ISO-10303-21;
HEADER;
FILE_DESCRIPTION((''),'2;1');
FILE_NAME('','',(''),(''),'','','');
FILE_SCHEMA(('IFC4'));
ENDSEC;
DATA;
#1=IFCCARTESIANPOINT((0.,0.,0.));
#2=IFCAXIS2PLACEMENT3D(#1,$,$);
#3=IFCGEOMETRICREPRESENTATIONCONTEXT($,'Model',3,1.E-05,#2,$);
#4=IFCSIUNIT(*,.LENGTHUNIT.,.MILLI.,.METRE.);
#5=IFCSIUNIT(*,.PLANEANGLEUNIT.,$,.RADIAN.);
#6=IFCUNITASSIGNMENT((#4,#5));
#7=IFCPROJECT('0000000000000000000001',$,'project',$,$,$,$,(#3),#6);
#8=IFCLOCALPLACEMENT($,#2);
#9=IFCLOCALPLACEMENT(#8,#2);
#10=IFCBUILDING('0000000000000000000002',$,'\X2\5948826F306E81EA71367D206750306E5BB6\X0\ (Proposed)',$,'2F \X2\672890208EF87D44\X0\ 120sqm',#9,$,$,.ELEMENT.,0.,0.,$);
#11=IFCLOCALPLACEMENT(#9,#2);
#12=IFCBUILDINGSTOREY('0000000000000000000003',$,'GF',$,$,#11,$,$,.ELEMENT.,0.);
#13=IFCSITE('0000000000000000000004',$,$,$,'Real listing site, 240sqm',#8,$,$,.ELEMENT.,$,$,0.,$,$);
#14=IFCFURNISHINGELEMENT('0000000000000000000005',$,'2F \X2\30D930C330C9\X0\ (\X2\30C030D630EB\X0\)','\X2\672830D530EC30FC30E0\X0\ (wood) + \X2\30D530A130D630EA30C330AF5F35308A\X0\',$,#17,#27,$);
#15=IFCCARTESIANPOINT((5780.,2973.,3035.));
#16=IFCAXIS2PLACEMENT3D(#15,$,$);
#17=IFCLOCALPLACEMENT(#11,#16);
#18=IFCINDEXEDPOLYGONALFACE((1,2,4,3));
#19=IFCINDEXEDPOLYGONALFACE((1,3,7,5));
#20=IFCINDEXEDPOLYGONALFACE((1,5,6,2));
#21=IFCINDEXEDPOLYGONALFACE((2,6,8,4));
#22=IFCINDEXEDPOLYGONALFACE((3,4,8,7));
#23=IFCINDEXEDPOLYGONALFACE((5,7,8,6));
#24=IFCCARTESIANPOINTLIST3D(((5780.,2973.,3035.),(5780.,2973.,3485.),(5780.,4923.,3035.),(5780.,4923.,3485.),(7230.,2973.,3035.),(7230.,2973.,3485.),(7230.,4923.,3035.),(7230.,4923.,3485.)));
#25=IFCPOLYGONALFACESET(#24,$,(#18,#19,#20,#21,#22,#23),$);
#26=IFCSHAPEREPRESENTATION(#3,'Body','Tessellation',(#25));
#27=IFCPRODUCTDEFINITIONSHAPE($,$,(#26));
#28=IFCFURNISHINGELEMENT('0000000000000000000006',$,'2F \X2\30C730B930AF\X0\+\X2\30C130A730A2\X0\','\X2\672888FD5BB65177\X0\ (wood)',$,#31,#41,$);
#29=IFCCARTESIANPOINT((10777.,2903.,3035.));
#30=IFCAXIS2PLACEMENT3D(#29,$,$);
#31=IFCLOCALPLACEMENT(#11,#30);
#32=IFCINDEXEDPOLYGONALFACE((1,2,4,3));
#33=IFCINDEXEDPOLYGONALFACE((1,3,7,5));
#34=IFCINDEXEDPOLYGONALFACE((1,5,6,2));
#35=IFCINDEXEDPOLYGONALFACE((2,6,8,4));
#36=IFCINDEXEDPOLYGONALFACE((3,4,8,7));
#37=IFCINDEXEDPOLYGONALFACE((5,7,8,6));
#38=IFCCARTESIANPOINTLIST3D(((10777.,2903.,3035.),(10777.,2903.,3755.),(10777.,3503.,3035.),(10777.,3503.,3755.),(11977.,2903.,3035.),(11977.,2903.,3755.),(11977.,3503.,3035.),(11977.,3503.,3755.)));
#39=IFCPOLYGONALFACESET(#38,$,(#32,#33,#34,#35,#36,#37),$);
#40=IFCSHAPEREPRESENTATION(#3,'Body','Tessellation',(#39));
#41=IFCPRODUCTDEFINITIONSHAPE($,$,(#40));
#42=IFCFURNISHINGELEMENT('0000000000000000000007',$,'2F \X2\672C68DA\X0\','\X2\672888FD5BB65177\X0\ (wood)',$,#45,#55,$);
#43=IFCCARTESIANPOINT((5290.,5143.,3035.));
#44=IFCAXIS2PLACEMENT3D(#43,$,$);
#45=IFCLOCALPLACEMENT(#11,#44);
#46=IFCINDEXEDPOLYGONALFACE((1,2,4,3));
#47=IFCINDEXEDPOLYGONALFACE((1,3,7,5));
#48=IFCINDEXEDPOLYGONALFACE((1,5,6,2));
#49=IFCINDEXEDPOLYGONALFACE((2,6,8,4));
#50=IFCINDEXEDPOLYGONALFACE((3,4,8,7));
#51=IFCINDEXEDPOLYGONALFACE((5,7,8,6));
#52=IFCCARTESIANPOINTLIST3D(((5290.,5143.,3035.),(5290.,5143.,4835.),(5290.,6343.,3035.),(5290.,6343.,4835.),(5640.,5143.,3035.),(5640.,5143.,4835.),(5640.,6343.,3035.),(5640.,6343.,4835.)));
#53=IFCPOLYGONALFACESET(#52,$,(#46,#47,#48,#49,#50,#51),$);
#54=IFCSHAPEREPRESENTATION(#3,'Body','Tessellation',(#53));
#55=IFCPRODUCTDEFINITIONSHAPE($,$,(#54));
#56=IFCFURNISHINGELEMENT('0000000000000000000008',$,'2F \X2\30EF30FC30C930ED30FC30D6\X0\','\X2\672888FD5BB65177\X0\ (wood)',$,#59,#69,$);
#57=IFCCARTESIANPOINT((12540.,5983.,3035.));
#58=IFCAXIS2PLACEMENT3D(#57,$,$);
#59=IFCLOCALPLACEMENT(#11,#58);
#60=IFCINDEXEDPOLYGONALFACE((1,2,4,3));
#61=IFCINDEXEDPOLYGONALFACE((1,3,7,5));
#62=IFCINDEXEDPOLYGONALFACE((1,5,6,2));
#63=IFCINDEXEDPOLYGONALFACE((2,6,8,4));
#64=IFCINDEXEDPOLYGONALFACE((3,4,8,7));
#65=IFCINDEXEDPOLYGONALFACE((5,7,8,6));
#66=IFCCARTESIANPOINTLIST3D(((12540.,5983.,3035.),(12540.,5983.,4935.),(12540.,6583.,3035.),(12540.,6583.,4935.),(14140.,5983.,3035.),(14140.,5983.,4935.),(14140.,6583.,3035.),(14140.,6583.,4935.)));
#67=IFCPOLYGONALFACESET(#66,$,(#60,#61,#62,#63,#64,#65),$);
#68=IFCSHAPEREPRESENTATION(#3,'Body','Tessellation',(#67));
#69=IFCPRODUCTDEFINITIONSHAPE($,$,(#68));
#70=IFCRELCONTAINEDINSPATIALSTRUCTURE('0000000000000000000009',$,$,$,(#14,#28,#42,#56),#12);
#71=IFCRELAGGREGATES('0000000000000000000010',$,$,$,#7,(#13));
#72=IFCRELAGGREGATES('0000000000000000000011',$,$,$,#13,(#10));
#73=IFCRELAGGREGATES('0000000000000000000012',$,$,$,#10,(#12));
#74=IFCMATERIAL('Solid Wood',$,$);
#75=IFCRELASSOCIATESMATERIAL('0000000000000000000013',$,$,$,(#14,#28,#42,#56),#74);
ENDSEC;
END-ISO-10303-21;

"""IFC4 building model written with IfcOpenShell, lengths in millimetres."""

from ifc_helpers import new_model, si_unit, frame, frame_2d, origin, place, context, project, spatial, rectangle, extrude, material, element, save


model = new_model("IFC4")

# Units and contexts
model_context = context("Model", 3, precision=1e-05, world=origin())
ifc_project = project(units=[si_unit("LENGTHUNIT", "METRE", prefix="MILLI"), si_unit("PLANEANGLEUNIT", "RADIAN")], contexts=[model_context])

# Site, building, storey
site_placement = place(None, origin())
site = spatial("IfcSite", under=ifc_project, at=site_placement, ObjectType="Real listing site, 240sqm", CompositionType="ELEMENT", RefElevation=0.0)
building_placement = place(site_placement, origin())
building = spatial("IfcBuilding", under=site, at=building_placement, Name="奈良の自然素材の家 (Proposed)", ObjectType="2F 木造軸組 120sqm", CompositionType="ELEMENT", ElevationOfRefHeight=0.0, ElevationOfTerrain=0.0)
storey_placement = place(building_placement, origin())
storey = spatial("IfcBuildingStorey", under=building, at=storey_placement, Name="GF", CompositionType="ELEMENT", Elevation=0.0)

# Shared definitions
ifc_material_1 = material(Name="Solid Wood")

# Furnishing elements
furnishing_1_placement = place(storey_placement, frame((5780.0, 2973.0, 3035.0)))
element("IfcFurnishingElement", 1, at=furnishing_1_placement, inside=storey, material=ifc_material_1, Name="2F ベッド (ダブル)", Description="木フレーム (wood) + ファブリック張り", context=model_context, shape_type="SweptSolid", body=[
    extrude(rectangle(XDim=1450.0, YDim=1950.0, at=frame_2d((725.0, 975.0))), frame((5780.0, 2973.0, 3035.0)), (0.0, 0.0, 1.0), 450.0),
])
furnishing_2_placement = place(storey_placement, frame((10777.0, 2903.0, 3035.0)))
element("IfcFurnishingElement", 2, at=furnishing_2_placement, inside=storey, material=ifc_material_1, Name="2F デスク+チェア", Description="木製家具 (wood)", context=model_context, shape_type="SweptSolid", body=[
    extrude(rectangle(XDim=1200.0, YDim=600.0, at=frame_2d((600.0, 300.0))), frame((10777.0, 2903.0, 3035.0)), (0.0, 0.0, 1.0), 720.0),
])
furnishing_3_placement = place(storey_placement, frame((5290.0, 5143.0, 3035.0)))
element("IfcFurnishingElement", 3, at=furnishing_3_placement, inside=storey, material=ifc_material_1, Name="2F 本棚", Description="木製家具 (wood)", context=model_context, shape_type="SweptSolid", body=[
    extrude(rectangle(XDim=350.0, YDim=1200.0, at=frame_2d((175.0, 600.0))), frame((5290.0, 5143.0, 3035.0)), (0.0, 0.0, 1.0), 1800.0),
])
furnishing_4_placement = place(storey_placement, frame((12540.0, 5983.0, 3035.0)))
element("IfcFurnishingElement", 4, at=furnishing_4_placement, inside=storey, material=ifc_material_1, Name="2F ワードローブ", Description="木製家具 (wood)", context=model_context, shape_type="SweptSolid", body=[
    extrude(rectangle(XDim=1600.0, YDim=600.0, at=frame_2d((800.0, 300.0))), frame((12540.0, 5983.0, 3035.0)), (0.0, 0.0, 1.0), 1900.0),
])

save(model, "model.ifc")
